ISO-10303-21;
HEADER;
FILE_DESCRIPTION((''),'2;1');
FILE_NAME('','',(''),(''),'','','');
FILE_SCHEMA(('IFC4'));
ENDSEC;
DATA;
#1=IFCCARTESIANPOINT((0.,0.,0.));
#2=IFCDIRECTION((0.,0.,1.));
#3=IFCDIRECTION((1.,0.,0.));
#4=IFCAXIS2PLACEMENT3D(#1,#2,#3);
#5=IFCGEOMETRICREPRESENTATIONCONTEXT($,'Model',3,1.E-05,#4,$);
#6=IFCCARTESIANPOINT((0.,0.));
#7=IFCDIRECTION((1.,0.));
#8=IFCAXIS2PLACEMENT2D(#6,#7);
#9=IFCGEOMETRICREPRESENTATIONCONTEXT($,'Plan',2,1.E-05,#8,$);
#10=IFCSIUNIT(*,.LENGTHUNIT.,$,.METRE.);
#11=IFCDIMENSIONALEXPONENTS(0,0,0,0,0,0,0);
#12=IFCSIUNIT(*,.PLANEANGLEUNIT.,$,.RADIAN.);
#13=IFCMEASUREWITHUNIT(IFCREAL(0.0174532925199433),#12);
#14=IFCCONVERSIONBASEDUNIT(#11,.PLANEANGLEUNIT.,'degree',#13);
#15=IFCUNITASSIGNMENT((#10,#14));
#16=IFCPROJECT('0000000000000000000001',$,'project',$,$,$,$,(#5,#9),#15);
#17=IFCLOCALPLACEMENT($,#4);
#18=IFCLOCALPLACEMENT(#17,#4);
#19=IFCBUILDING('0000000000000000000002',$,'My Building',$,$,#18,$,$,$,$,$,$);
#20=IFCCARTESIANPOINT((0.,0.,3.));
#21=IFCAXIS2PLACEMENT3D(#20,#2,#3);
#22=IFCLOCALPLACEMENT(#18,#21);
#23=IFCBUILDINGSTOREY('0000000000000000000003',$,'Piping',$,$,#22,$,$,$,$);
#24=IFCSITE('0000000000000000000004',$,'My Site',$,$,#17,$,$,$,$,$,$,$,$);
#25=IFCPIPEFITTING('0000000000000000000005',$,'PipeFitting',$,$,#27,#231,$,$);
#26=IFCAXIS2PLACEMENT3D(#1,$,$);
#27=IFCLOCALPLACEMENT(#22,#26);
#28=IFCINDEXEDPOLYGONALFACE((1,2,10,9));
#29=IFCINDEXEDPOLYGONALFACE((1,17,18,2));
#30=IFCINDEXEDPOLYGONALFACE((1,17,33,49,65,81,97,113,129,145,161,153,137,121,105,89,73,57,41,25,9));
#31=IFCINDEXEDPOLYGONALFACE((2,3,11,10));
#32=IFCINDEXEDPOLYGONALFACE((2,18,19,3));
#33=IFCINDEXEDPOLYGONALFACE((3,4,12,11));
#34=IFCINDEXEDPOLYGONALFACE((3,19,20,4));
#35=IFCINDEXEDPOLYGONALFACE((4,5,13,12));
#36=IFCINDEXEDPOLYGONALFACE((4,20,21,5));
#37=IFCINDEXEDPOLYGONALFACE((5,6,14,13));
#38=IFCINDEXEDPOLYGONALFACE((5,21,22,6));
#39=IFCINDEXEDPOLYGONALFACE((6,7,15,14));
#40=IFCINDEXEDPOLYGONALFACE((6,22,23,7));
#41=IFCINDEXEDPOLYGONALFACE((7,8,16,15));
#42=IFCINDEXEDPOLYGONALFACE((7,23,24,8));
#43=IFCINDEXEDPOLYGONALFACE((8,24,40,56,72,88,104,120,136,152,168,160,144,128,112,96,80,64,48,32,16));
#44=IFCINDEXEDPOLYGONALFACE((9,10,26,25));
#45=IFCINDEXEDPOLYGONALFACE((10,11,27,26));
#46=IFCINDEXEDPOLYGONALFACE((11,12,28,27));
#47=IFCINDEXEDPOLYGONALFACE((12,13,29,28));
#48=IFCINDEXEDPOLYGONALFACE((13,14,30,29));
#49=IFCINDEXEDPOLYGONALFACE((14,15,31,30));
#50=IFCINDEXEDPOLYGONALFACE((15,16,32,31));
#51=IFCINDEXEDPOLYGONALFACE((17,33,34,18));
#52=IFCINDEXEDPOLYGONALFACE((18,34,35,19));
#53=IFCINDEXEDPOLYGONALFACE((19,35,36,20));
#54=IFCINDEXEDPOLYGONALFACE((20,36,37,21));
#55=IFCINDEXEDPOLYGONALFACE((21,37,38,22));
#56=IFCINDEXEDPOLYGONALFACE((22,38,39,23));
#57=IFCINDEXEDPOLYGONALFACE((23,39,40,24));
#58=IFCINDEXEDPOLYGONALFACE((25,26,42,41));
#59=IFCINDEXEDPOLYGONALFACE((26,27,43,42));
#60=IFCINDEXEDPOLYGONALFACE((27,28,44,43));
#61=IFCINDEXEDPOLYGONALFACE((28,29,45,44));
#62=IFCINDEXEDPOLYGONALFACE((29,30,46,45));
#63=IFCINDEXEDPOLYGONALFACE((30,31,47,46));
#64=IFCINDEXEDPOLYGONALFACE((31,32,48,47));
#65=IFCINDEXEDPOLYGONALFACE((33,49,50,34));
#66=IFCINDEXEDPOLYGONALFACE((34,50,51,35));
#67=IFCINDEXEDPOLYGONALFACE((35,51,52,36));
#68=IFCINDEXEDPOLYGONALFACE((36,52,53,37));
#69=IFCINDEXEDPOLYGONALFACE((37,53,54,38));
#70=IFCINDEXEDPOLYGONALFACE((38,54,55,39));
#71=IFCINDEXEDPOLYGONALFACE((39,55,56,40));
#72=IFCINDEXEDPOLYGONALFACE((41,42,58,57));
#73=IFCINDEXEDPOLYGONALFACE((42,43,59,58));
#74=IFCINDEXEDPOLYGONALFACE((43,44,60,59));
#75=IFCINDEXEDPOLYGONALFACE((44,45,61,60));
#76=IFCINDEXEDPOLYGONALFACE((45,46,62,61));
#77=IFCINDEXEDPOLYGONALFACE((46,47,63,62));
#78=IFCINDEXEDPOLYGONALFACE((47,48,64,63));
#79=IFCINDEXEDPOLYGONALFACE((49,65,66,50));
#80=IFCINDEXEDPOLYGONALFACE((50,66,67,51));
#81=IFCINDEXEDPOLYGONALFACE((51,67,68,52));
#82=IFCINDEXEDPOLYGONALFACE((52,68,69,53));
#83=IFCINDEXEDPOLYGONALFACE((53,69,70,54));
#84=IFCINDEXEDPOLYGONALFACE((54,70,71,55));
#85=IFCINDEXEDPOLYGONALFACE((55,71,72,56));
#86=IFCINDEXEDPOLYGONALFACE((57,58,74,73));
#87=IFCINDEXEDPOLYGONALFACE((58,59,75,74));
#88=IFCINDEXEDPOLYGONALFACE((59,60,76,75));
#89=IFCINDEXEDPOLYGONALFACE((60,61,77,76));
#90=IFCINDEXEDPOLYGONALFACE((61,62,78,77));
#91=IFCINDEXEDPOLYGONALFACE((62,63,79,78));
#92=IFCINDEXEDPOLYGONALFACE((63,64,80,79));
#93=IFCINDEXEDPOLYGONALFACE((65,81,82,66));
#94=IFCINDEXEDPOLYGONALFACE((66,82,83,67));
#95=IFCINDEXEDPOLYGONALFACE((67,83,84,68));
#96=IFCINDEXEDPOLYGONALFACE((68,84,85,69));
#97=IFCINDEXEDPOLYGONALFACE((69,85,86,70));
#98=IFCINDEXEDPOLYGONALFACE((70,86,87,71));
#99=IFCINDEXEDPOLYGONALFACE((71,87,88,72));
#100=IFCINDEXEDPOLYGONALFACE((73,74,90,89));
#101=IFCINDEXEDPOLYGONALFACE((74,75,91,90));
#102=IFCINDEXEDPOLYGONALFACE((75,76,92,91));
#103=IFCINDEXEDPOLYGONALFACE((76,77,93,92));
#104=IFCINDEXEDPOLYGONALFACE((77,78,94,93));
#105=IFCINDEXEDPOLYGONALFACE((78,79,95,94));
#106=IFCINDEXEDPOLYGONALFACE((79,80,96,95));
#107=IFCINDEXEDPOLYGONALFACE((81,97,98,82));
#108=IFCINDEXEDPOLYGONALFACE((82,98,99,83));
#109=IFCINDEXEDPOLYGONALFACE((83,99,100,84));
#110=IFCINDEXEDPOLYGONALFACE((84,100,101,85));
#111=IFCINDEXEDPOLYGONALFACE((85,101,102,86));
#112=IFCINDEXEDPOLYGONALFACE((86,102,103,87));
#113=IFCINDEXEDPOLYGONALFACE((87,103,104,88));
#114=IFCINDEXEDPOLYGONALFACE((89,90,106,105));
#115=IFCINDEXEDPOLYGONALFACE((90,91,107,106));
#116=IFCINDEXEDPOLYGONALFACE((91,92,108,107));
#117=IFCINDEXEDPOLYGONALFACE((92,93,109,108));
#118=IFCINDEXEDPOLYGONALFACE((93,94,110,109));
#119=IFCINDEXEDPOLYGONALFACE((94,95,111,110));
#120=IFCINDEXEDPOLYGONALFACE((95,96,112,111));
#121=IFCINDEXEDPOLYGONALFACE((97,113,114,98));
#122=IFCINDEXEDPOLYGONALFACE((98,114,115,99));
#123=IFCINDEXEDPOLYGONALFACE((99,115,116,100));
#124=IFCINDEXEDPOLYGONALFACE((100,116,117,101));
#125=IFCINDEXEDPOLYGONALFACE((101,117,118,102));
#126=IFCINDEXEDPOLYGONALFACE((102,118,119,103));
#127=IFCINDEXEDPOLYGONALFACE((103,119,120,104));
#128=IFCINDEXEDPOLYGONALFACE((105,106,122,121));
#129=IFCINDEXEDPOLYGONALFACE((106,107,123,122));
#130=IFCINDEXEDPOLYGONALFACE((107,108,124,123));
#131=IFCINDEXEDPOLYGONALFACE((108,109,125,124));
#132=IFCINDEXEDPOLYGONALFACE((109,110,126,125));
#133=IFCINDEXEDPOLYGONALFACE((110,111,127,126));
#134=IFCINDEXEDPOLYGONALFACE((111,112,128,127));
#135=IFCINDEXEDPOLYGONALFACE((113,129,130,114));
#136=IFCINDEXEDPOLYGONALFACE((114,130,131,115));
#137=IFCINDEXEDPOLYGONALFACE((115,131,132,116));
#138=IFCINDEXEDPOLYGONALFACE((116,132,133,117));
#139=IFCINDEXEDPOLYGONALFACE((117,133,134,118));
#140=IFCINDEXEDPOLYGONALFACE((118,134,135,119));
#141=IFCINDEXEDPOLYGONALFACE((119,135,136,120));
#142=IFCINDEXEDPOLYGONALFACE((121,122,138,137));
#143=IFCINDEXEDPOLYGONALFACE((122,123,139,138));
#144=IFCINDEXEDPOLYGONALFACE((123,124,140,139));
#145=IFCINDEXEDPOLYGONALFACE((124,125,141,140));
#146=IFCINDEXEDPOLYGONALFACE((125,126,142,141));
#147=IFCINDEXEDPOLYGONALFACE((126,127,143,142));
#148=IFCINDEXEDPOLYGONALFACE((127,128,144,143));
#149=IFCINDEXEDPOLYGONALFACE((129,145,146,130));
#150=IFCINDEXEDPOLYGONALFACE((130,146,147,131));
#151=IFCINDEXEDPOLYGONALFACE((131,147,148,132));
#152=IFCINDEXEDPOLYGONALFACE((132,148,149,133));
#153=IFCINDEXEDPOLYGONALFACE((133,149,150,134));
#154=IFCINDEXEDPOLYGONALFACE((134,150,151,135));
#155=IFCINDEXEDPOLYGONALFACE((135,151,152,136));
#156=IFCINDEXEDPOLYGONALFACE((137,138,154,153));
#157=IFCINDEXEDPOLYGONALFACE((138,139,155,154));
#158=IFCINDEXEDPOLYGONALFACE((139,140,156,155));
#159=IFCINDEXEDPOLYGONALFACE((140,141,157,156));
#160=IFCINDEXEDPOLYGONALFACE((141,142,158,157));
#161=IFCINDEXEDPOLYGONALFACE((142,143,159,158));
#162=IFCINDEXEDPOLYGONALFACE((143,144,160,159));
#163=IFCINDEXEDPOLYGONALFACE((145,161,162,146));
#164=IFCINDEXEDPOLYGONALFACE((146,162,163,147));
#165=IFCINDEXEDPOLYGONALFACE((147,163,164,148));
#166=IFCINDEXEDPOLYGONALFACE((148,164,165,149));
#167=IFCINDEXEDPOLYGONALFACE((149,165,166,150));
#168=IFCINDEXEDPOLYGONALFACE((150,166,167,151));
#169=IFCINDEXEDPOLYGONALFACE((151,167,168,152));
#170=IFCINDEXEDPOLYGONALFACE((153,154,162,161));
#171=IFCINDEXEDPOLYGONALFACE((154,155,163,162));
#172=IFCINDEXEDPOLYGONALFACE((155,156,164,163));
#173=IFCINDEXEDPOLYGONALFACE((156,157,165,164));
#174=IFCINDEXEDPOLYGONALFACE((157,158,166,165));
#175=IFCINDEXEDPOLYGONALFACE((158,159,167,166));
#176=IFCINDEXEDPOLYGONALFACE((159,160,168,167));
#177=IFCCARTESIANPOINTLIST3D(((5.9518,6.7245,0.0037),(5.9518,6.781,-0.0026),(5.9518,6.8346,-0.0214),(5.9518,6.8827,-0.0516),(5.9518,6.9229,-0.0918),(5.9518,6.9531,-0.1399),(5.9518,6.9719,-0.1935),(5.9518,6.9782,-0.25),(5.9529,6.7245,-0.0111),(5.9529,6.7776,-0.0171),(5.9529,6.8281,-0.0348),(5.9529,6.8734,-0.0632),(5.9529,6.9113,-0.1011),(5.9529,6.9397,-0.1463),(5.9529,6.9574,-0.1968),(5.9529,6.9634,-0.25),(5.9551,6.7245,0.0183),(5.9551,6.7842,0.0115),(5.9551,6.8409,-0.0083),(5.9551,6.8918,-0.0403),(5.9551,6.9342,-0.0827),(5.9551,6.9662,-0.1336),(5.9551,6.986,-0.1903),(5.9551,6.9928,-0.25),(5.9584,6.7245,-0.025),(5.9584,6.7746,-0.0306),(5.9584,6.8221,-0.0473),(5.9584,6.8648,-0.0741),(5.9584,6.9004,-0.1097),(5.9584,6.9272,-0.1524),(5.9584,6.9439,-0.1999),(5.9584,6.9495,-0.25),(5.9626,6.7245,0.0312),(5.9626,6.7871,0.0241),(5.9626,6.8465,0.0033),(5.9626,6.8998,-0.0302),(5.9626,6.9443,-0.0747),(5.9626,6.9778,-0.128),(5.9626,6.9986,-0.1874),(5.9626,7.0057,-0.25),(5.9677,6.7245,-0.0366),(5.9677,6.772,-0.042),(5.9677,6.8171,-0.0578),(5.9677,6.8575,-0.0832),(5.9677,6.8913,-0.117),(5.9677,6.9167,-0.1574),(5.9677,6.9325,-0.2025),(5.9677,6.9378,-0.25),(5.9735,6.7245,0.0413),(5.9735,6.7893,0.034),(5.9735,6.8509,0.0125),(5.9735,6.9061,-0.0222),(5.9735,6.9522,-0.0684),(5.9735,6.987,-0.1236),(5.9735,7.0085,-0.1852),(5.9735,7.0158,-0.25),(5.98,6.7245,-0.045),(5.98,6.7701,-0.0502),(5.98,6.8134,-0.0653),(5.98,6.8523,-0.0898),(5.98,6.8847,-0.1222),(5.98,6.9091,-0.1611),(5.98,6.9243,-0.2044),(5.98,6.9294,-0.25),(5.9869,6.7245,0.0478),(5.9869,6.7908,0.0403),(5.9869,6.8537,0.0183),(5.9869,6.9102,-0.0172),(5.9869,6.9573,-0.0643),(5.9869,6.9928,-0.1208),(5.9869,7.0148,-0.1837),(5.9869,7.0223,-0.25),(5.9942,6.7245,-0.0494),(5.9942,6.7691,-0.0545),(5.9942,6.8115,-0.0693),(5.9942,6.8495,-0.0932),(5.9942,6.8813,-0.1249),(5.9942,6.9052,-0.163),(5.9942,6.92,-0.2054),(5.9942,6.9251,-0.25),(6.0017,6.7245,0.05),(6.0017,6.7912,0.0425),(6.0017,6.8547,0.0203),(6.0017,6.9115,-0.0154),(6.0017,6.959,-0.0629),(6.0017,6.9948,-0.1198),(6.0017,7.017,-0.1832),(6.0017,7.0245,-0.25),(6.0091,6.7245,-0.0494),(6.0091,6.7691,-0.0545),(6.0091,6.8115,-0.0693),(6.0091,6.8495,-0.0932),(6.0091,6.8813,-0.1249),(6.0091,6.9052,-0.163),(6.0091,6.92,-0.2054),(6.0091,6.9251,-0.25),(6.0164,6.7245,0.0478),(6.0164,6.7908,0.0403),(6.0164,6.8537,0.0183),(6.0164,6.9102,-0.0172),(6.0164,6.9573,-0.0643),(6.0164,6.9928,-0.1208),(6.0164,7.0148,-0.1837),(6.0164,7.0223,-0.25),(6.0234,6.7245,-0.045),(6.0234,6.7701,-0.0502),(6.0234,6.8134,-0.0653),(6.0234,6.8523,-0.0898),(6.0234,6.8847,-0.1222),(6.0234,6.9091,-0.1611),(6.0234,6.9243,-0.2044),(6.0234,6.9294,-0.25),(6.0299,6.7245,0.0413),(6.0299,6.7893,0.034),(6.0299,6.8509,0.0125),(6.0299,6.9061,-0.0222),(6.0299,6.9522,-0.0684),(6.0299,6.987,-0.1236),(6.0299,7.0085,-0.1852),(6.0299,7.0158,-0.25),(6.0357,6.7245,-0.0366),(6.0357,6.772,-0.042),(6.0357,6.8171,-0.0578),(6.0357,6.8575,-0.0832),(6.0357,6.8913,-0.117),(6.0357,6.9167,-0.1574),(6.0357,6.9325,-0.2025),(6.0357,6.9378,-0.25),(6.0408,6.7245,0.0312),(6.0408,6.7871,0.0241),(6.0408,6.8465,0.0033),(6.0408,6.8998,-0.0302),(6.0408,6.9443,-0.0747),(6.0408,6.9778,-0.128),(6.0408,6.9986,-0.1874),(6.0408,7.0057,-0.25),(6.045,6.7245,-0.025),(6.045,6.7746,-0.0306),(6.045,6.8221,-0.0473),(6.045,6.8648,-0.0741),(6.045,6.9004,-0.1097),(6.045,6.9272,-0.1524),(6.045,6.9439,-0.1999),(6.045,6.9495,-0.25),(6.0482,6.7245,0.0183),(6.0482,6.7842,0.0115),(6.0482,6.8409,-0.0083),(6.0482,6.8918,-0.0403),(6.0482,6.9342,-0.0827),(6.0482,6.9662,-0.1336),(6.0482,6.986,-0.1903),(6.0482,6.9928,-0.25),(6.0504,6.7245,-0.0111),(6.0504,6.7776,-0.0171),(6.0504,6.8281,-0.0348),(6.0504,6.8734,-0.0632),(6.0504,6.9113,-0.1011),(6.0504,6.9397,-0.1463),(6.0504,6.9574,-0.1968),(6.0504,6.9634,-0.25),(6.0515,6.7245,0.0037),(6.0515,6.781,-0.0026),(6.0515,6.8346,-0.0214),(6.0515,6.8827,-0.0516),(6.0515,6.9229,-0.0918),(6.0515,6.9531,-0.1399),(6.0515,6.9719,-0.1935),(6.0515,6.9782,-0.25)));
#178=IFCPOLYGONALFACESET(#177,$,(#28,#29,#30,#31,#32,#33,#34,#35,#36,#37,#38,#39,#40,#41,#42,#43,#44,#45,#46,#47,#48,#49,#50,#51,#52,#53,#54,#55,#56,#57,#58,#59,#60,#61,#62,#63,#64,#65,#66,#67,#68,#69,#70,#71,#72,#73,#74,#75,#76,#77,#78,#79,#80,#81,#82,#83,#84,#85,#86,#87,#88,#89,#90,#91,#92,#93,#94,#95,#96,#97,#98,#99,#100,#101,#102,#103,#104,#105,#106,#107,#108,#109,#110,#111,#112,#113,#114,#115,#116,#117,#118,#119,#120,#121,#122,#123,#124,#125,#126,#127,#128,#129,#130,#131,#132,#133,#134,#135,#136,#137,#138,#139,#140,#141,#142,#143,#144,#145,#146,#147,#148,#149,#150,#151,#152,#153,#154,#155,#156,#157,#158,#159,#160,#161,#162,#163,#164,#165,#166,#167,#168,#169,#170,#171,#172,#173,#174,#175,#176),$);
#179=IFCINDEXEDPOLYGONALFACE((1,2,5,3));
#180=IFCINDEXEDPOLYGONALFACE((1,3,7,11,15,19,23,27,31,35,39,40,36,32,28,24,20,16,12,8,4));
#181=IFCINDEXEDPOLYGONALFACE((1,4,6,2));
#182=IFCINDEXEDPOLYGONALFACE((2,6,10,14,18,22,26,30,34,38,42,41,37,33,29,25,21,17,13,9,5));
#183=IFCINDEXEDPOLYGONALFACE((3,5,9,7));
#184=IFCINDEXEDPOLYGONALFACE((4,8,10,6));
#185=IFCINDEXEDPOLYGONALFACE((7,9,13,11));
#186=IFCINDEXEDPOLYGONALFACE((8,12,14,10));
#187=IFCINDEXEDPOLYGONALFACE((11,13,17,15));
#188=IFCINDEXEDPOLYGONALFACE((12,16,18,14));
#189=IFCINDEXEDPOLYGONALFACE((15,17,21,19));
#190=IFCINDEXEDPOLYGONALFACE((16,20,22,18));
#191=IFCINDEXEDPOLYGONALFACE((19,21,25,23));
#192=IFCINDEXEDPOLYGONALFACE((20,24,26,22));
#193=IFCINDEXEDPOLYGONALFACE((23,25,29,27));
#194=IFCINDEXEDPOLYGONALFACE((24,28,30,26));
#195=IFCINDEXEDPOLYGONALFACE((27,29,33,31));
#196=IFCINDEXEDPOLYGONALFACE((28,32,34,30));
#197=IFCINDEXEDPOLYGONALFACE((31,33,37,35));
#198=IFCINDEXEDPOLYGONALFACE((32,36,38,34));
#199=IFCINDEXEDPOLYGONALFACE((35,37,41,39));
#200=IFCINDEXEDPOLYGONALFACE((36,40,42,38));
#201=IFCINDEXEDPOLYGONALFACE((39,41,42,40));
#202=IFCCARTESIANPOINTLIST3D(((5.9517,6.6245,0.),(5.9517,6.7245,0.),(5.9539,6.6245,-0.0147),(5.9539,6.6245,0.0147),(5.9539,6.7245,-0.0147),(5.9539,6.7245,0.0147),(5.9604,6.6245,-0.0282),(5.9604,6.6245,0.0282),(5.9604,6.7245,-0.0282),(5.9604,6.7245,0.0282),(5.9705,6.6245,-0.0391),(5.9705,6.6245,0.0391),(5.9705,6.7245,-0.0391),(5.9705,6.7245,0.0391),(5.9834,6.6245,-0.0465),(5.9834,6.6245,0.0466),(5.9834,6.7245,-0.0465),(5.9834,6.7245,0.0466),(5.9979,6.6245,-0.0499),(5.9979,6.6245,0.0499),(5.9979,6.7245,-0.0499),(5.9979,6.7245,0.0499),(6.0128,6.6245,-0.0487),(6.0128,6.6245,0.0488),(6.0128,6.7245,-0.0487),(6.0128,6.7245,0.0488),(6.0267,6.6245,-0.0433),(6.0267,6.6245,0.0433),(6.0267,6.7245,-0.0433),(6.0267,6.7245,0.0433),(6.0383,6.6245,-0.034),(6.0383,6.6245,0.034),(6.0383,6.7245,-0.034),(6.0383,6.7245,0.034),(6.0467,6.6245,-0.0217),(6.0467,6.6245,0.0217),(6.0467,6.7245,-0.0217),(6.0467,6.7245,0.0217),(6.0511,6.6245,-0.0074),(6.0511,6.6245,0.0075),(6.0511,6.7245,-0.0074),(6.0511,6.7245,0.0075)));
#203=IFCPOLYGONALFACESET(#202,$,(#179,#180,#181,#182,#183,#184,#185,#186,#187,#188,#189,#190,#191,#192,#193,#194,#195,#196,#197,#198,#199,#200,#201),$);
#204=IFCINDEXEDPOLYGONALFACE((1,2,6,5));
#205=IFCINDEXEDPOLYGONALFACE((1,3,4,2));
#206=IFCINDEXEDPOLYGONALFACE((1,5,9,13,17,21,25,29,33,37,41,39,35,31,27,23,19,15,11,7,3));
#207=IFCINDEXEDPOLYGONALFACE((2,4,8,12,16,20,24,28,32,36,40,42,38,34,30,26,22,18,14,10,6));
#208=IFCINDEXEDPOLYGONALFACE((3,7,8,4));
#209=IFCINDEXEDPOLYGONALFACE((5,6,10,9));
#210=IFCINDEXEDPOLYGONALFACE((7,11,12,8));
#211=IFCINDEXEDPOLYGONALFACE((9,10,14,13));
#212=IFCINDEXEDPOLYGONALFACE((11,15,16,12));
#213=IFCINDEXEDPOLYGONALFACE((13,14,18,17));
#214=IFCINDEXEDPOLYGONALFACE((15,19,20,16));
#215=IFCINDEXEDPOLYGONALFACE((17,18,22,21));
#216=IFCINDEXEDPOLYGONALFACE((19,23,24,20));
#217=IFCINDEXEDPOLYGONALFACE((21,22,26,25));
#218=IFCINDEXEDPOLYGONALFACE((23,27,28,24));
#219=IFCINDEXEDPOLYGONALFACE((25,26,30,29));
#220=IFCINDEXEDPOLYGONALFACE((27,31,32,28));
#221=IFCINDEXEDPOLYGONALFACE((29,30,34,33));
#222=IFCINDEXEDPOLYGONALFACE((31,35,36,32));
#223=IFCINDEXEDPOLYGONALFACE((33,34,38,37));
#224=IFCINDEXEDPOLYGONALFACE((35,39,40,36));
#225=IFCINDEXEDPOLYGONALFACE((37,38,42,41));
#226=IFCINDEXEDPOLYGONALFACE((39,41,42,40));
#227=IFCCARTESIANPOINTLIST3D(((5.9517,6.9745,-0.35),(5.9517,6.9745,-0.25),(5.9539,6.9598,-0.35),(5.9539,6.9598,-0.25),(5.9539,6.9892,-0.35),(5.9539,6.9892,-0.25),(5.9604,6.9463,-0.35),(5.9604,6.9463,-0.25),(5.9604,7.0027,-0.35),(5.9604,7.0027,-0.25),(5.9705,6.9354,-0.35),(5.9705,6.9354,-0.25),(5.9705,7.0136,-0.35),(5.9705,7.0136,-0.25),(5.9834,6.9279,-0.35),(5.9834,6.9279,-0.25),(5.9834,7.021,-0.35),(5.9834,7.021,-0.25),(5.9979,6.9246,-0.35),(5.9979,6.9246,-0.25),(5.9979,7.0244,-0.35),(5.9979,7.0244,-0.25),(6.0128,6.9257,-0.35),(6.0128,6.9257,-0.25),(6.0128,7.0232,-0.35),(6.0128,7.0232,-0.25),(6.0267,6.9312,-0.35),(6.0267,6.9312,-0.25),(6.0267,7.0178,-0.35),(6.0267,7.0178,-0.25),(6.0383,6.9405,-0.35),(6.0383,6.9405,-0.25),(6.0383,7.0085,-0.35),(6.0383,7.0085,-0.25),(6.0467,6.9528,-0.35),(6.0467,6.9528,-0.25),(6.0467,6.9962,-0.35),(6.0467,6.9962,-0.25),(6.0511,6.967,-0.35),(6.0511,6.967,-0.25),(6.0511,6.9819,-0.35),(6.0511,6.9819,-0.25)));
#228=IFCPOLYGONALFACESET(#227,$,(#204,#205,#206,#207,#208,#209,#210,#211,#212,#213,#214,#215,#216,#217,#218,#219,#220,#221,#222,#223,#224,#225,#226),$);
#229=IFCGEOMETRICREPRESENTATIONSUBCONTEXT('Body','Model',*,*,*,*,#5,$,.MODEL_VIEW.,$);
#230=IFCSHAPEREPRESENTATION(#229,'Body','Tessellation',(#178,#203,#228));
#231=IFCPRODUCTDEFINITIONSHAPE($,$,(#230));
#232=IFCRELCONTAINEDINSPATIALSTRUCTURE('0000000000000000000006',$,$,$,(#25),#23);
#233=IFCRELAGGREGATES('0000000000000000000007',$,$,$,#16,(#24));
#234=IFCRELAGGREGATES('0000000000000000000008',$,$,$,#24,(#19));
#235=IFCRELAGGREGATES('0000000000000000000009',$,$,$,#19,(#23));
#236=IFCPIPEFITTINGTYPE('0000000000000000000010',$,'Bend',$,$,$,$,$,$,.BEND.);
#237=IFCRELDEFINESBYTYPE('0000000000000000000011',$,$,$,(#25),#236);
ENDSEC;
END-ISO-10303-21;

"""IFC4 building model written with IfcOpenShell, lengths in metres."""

from ifc_helpers import new_model, entity, si_unit, converted_unit, frame, origin_with_axes, origin_2d_with_axis, place, context, subcontext, project, spatial, circle, extrude, source, transform, mapped, type_object, type_shapes, element, save


model = new_model("IFC4")

# Units and contexts
model_context = context("Model", 3, precision=1e-05, world=origin_with_axes())
plan_context = context("Plan", 2, precision=1e-05, world=origin_2d_with_axis())
body_context = subcontext(model_context, "Body", "Model", "MODEL_VIEW")
ifc_project = project(units=[si_unit("LENGTHUNIT", "METRE"), converted_unit("PLANEANGLEUNIT", "degree", entity("IfcReal", 0.0174532925199433), si_unit("PLANEANGLEUNIT", "RADIAN"), dimensions=[0, 0, 0, 0, 0, 0, 0])], contexts=[model_context, plan_context])

# Site, building, storey
site_placement = place(None, origin_with_axes())
site = spatial("IfcSite", under=ifc_project, at=site_placement, Name="My Site")
building_placement = place(site_placement, origin_with_axes())
building = spatial("IfcBuilding", under=site, at=building_placement, Name="My Building")
storey_placement = place(building_placement, frame((0.0, 0.0, 3.0), z_axis=(0.0, 0.0, 1.0), x_axis=(1.0, 0.0, 0.0)))
storey = spatial("IfcBuildingStorey", under=building, at=storey_placement, Name="Piping")

# Pipe fitting
pipe_fitting_type = type_object("IfcPipeFittingType", Name="Bend", PredefinedType="BEND")
shared_shape = source(origin_with_axes(), body_context, "Body", "SolidModel", [
    entity("IfcSweptDiskSolid", entity("IfcIndexedPolyCurve", entity("IfcCartesianPointList3D", [[0.0, 0.0, 0.1], [0.0, -0.0732, 0.2768], [0.0, -0.25, 0.35]]), [entity("IfcArcIndex", [1, 2, 3])]), 0.05),
    extrude(circle(Radius=0.05), origin_with_axes(), (0.0, 0.0, 1.0), 0.1),
    extrude(circle(Radius=0.05), frame((0.0, -0.25, 0.35), z_axis=(0.0, -1.0, 0.0), x_axis=(1.0, 0.0, 0.0)), (0.0, 0.0, 1.0), 0.1),
])
type_shapes(pipe_fitting_type, [shared_shape])
for number, where, z_axis, x_axis, name in (
    (1, (6.0017, 6.6245, 0.0), (0.0, 1.0, 0.0), (-1.0, 0.0, 0.0), "PipeFitting"),
):
    element("IfcPipeFitting", number, at=place(storey_placement, frame(where, z_axis=z_axis, x_axis=x_axis)), inside=storey, type_object=pipe_fitting_type, Name=name, context=body_context, shape_type="MappedRepresentation", body=[
        mapped(shared_shape, transform((0.0, 0.0, 0.0), x_axis=(1.0, 0.0, 0.0), y_axis=(0.0, 1.0, 0.0), z_axis=(0.0, 0.0, 1.0), scale=1.0)),
    ])

save(model, "model.ifc")
